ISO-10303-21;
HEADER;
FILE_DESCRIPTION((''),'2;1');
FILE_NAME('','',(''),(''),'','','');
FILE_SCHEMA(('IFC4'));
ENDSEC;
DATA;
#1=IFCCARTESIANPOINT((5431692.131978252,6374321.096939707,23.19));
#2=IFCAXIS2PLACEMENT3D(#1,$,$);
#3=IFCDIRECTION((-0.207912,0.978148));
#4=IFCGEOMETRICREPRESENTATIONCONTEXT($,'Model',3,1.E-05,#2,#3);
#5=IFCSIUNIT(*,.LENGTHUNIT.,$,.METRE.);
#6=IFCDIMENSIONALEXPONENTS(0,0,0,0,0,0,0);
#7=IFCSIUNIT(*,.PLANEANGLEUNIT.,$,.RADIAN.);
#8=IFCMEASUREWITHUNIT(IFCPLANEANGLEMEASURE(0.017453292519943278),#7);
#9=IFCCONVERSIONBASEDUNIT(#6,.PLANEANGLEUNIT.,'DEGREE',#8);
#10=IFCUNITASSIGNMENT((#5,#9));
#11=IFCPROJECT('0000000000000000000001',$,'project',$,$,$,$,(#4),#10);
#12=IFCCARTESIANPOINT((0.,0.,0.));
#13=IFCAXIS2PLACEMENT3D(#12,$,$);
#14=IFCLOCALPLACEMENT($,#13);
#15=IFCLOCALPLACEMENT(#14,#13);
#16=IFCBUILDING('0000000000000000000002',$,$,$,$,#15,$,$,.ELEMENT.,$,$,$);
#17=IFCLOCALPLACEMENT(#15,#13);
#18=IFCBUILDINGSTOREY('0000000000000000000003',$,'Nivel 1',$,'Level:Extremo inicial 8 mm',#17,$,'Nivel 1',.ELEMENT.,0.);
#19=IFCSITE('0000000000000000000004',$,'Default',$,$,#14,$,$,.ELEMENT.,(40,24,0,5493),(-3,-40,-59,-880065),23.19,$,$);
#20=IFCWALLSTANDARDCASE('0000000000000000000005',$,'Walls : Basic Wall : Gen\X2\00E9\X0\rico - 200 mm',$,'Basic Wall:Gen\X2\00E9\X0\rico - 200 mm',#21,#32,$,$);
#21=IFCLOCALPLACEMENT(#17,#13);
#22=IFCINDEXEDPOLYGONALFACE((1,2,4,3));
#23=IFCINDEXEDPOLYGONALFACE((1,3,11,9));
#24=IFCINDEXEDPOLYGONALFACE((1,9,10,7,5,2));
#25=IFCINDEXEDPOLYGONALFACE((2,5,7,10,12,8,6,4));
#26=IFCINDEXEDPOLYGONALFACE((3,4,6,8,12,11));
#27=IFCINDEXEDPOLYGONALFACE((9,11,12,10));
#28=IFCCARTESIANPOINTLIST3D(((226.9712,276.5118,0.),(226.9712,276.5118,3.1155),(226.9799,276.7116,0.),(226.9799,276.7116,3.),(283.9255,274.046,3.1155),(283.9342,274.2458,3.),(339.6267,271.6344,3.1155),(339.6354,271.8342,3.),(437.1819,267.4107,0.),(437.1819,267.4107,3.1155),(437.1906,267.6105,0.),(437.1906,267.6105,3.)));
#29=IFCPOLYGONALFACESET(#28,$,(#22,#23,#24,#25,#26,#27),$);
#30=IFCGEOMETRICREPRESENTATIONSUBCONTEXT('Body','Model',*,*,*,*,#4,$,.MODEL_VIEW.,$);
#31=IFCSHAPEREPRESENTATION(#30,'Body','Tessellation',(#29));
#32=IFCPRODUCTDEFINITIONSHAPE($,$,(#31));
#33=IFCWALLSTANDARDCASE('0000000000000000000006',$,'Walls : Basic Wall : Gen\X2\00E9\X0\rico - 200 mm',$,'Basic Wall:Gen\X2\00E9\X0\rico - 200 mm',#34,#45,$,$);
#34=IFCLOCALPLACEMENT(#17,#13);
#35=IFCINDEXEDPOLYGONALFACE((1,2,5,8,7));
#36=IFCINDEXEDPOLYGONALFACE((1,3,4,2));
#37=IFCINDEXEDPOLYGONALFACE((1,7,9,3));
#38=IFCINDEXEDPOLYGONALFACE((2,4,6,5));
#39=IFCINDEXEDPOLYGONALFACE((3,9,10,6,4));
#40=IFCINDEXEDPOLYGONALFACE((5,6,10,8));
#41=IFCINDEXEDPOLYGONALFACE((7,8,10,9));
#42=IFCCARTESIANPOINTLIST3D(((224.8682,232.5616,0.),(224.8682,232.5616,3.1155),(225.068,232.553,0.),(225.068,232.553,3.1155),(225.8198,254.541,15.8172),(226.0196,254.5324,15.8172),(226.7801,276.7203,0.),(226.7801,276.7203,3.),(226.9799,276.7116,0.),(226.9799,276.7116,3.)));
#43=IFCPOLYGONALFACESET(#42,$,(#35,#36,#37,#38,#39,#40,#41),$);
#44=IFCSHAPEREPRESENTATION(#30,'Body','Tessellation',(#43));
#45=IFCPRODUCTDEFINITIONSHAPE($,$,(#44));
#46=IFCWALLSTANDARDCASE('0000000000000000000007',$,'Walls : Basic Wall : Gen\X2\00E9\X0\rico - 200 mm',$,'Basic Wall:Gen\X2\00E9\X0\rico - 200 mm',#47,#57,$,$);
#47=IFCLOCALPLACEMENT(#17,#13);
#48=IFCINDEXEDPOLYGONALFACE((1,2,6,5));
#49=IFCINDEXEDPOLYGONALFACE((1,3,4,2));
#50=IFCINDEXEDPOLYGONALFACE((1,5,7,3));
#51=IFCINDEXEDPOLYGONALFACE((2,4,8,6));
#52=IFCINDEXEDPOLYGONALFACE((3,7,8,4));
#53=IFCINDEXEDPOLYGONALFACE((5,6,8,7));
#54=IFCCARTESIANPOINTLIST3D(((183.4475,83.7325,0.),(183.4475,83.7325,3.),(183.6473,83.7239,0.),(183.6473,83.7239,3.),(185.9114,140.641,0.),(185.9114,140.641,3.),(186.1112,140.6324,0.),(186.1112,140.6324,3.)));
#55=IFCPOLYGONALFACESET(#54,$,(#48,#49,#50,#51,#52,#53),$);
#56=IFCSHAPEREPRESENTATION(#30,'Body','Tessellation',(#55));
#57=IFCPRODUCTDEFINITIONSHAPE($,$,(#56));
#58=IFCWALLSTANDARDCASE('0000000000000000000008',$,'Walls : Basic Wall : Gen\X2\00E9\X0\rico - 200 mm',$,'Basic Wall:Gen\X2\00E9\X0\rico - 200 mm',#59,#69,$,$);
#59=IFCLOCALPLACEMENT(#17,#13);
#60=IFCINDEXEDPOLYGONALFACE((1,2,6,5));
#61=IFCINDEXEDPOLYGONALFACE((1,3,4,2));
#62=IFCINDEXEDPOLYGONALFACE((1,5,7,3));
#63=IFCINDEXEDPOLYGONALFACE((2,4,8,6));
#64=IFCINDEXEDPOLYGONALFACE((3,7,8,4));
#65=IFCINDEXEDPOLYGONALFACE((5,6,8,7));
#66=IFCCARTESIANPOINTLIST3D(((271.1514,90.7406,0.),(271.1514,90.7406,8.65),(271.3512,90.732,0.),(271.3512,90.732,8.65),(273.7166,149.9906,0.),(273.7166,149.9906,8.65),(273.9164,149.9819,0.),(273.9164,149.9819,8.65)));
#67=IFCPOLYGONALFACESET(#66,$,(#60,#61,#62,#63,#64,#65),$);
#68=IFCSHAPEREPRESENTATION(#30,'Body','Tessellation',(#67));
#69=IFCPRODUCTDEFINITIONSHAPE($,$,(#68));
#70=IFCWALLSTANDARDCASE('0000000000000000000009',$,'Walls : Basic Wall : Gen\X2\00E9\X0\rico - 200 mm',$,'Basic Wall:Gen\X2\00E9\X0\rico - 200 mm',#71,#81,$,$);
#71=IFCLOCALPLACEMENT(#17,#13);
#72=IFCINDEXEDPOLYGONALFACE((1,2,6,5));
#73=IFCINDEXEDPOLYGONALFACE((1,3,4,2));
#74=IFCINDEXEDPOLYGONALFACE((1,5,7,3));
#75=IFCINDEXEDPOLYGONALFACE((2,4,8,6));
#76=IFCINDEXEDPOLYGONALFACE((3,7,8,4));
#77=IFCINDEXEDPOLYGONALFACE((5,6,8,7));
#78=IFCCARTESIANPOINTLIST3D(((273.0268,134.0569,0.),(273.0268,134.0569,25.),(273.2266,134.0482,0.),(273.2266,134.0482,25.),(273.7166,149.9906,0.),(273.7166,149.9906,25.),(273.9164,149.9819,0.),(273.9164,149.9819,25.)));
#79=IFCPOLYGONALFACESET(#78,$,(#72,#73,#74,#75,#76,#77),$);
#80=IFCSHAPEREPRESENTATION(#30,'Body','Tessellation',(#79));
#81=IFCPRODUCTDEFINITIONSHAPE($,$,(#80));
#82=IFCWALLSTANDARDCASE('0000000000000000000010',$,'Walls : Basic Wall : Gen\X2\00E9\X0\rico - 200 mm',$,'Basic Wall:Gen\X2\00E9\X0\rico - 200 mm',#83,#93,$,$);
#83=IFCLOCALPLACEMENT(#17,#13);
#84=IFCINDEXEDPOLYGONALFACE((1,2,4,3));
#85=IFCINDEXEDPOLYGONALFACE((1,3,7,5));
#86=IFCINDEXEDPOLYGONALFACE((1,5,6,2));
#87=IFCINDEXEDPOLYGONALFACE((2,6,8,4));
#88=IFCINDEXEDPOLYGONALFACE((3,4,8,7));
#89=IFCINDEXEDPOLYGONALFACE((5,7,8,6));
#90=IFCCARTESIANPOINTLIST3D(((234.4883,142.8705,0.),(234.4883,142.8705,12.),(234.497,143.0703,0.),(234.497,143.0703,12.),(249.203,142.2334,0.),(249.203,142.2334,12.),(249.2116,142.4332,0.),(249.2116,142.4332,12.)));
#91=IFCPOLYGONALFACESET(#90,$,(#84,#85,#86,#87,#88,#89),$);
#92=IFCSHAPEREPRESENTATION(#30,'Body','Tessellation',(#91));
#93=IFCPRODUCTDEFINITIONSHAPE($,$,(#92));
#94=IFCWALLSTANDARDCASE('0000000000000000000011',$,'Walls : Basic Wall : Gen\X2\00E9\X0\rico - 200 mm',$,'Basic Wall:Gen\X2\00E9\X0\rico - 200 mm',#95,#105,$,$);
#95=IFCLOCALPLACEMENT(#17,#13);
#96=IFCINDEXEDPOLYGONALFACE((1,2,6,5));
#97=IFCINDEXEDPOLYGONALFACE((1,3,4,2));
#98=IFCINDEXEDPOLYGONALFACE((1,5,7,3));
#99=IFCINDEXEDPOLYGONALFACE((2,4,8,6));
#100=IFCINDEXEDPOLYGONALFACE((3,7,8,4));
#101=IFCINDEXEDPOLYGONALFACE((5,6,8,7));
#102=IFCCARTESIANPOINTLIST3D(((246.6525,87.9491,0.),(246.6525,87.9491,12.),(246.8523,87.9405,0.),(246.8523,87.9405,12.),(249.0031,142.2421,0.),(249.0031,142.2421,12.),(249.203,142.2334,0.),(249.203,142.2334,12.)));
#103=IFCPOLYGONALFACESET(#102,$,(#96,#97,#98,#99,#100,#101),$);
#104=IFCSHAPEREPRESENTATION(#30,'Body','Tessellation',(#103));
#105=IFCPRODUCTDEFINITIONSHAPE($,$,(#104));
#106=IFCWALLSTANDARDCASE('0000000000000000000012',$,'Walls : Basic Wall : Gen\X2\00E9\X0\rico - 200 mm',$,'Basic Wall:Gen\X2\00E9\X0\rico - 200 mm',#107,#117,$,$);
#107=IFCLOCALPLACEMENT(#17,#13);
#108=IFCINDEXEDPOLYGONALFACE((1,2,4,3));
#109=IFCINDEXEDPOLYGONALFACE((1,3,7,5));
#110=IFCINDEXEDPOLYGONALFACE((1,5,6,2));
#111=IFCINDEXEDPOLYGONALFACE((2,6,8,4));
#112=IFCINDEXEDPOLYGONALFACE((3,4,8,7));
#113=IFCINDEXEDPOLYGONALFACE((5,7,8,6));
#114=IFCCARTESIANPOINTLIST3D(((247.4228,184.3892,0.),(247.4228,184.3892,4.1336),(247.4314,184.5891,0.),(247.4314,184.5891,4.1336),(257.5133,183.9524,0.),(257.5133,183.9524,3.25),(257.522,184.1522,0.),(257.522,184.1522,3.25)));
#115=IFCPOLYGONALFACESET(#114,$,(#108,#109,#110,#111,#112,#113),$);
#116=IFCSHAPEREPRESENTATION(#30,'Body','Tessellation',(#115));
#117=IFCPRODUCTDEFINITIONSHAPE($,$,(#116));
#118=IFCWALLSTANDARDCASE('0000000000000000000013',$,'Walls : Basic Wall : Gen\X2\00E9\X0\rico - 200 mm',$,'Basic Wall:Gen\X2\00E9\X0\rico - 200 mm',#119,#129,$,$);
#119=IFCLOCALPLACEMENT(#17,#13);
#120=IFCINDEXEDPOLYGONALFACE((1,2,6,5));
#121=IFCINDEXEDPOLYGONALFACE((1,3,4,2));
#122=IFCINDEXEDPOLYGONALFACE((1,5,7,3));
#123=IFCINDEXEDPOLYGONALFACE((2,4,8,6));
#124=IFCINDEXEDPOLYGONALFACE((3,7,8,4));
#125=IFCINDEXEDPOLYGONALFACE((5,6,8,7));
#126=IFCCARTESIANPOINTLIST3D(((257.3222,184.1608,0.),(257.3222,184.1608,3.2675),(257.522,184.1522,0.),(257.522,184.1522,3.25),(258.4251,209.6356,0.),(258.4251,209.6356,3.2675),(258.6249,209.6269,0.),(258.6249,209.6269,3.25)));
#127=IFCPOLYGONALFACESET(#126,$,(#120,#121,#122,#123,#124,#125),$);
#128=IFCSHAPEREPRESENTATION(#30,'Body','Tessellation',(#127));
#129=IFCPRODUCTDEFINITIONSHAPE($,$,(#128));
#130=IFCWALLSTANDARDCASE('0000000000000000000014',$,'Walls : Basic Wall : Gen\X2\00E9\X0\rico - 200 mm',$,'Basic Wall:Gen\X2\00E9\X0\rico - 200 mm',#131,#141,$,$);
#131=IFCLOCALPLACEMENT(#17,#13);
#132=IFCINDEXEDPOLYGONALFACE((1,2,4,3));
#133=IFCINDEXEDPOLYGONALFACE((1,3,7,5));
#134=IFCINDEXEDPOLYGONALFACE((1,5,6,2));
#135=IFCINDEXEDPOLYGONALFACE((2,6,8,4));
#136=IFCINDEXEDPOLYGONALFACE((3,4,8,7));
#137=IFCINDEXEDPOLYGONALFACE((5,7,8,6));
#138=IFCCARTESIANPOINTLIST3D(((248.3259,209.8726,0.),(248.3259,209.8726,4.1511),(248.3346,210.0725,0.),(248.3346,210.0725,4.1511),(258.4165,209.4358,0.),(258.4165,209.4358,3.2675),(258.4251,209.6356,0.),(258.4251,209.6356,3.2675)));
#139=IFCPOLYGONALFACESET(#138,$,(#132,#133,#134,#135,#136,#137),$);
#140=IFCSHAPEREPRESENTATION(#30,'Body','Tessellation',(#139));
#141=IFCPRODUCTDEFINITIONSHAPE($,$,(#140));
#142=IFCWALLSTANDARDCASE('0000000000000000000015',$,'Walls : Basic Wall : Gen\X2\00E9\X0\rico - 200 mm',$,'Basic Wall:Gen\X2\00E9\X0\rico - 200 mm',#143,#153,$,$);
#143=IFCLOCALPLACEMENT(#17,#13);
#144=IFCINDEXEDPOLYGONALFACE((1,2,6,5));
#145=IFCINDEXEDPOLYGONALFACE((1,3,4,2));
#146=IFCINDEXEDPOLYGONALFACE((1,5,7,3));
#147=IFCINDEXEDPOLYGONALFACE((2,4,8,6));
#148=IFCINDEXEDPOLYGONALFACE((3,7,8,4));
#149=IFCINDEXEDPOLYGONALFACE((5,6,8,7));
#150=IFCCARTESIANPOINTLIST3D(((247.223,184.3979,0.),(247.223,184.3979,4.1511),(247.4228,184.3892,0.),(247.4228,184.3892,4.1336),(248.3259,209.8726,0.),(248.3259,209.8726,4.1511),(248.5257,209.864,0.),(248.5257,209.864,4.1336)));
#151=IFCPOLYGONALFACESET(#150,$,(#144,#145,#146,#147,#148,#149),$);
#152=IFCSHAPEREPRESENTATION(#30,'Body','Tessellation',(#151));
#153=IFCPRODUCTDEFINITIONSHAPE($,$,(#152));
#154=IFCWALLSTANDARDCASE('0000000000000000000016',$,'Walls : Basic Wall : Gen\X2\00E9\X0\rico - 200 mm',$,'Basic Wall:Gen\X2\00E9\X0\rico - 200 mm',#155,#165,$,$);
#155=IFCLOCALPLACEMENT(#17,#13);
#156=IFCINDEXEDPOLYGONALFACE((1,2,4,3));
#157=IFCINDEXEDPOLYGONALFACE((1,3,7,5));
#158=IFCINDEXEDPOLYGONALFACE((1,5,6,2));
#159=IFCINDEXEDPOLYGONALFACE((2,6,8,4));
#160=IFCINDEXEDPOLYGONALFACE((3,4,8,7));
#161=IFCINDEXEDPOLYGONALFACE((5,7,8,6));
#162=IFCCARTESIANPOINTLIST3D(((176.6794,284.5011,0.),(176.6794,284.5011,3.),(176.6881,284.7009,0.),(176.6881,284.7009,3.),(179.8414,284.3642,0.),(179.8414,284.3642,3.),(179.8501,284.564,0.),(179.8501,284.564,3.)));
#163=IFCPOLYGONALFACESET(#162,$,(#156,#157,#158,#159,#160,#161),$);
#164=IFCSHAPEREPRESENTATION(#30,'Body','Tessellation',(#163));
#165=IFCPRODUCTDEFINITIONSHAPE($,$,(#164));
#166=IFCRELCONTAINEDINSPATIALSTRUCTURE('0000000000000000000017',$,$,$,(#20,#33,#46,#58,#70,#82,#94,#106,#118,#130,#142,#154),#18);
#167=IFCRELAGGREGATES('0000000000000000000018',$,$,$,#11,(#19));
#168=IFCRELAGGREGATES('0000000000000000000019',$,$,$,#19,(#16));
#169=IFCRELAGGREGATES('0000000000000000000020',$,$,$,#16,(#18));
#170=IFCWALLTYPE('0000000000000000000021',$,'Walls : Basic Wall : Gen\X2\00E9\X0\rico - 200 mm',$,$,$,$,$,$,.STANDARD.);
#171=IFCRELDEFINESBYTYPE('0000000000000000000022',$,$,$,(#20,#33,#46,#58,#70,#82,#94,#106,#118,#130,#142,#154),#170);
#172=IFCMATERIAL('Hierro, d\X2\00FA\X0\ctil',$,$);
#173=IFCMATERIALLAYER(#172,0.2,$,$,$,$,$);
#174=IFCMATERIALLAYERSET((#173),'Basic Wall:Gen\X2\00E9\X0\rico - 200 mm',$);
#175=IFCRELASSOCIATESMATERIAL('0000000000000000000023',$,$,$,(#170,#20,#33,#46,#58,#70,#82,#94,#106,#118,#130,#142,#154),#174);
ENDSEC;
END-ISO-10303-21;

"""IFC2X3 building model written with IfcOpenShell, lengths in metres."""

from ifc_helpers import new_model, entity, si_unit, converted_unit, direction, frame, frame_2d, origin, place, context, subcontext, project, spatial, polyline, rectangle, extrude, clip, bounded_halfspace, material, layer, layer_set, layer_usage, type_object, element, save


model = new_model("IFC2X3")

# Units and contexts
model_context = context("Model", 3, precision=1e-05, world=frame((5431692.131978252, 6374321.096939707, 23.19)), true_north=direction((-0.207912, 0.978148)))
body_context = subcontext(model_context, "Body", "Model", "MODEL_VIEW")
ifc_project = project(units=[si_unit("LENGTHUNIT", "METRE"), converted_unit("PLANEANGLEUNIT", "DEGREE", entity("IfcPlaneAngleMeasure", 0.017453292519943278), si_unit("PLANEANGLEUNIT", "RADIAN"), dimensions=[0, 0, 0, 0, 0, 0, 0])], contexts=[model_context])

# Site, building, storey
site_placement = place(None, origin())
site = spatial("IfcSite", under=ifc_project, at=site_placement, Name="Default", CompositionType="ELEMENT", RefLatitude=(40, 24, 0, 5493), RefLongitude=(-3, -40, -59, -880065), RefElevation=23.19)
building_placement = place(site_placement, origin())
building = spatial("IfcBuilding", under=site, at=building_placement, CompositionType="ELEMENT")
storey_placement = place(building_placement, origin())
storey = spatial("IfcBuildingStorey", under=building, at=storey_placement, Name="Nivel 1", ObjectType="Level:Extremo inicial 8 mm", LongName="Nivel 1", CompositionType="ELEMENT", Elevation=0.0)

# Walls
ifc_material_1 = material(Name="Hierro, dúctil")
ifc_layer_1 = layer(ifc_material_1, 0.2)
ifc_layer_set_1 = layer_set([ifc_layer_1], Name="Basic Wall:Genérico - 200 mm")
ifc_layer_usage_1 = layer_usage(ifc_layer_set_1, "AXIS2", "NEGATIVE", 0.1)
wall_type = type_object("IfcWallType", Name="Walls : Basic Wall : Genérico - 200 mm", PredefinedType="STANDARD", material=ifc_layer_set_1)
wall_1_placement = place(storey_placement, frame((226.9756, 276.6117, 0.0), z_axis=(0.0, 0.0, 1.0), x_axis=(0.999064, -0.043255, 0.0)))
element("IfcWallStandardCase", 1, at=wall_1_placement, inside=storey, type_object=wall_type, material=ifc_layer_usage_1, Name="Walls : Basic Wall : Genérico - 200 mm", ObjectType="Basic Wall:Genérico - 200 mm", context=body_context, shape_type="Clipping", body=[
    clip(clip(clip(extrude(rectangle(XDim=210.4076, YDim=0.2, at=frame_2d((105.2038, 0.0), x_axis=(-1.0, 0.0))), origin(), (0.0, 0.0, 1.0), 3.1155), bounded_halfspace(frame((0.0, -0.1, 3.1155), z_axis=(0.0, 0.5, 0.866025), x_axis=(-1.0, 0.0, 0.0)), False, frame((0.0, -0.1, 3.1155)), polyline([(0.0, 0.0), (57.0076, 0.0), (57.0076, 0.2), (0.0, 0.2), (0.0, 0.0)]))), bounded_halfspace(frame((112.761, -0.1, 3.1155), z_axis=(0.0, 0.5, 0.866025), x_axis=(-1.0, 0.0, 0.0)), False, frame((112.761, -0.1, 3.1155)), polyline([(0.0, 0.0), (97.4466, 0.0), (97.6466, 0.0), (97.6466, 0.2), (0.0, 0.2), (0.0, 0.0)]))), bounded_halfspace(frame((112.761, -0.1, 3.1155), z_axis=(0.0, 0.5, 0.866025), x_axis=(-1.0, 0.0, 0.0)), False, frame((112.761, -0.1, 3.1155)), polyline([(0.0, 0.0), (0.0, 0.2), (-55.7534, 0.2), (-55.7534, 0.0), (0.0, 0.0)]))),
])
ifc_layer_usage_2 = layer_usage(ifc_layer_set_1, "AXIS2", "NEGATIVE", 0.1)
wall_2_placement = place(storey_placement, frame((224.9681, 232.5573, 0.0), z_axis=(0.0, 0.0, 1.0), x_axis=(0.043255, 0.999064, 0.0)))
element("IfcWallStandardCase", 2, at=wall_2_placement, inside=storey, type_object=wall_type, material=ifc_layer_usage_2, Name="Walls : Basic Wall : Genérico - 200 mm", ObjectType="Basic Wall:Genérico - 200 mm", context=body_context, shape_type="Clipping", body=[
    clip(clip(extrude(rectangle(XDim=44.2, YDim=0.2, at=frame_2d((22.1, 0.0), x_axis=(-1.0, 0.0))), origin(), (0.0, 0.0, 1.0), 15.8172), bounded_halfspace(frame((22.0, -0.1, 15.8172), z_axis=(0.5, 0.0, 0.866025), x_axis=(0.0, 1.0, 0.0)), False, frame((22.0, -0.1, 15.8172)), polyline([(0.0, 0.0), (22.0, 0.0), (22.2, 0.0), (22.2, 0.2), (0.0, 0.2), (0.0, 0.0)]))), bounded_halfspace(frame((0.0, -0.1, 3.1155), z_axis=(-0.5, 0.0, 0.866025), x_axis=(0.0, -1.0, 0.0)), False, frame((0.0, -0.1, 3.1155)), polyline([(0.0, 0.0), (22.0, 0.0), (22.0, 0.2), (0.0, 0.2), (0.0, 0.0)]))),
])
ifc_layer_usage_3 = layer_usage(ifc_layer_set_1, "AXIS2", "NEGATIVE", 0.1)
wall_3_placement = place(storey_placement, frame((186.0113, 140.6367, 0.0), z_axis=(0.0, 0.0, 1.0), x_axis=(-0.043255, -0.999064, 0.0)))
element("IfcWallStandardCase", 3, at=wall_3_placement, inside=storey, type_object=wall_type, material=ifc_layer_usage_3, Name="Walls : Basic Wall : Genérico - 200 mm", ObjectType="Basic Wall:Genérico - 200 mm", context=body_context, shape_type="SweptSolid", body=[
    extrude(rectangle(XDim=56.9618, YDim=0.2, at=frame_2d((28.4809, 0.0), x_axis=(-1.0, 0.0))), origin(), (0.0, 0.0, 1.0), 3.0),
])
ifc_layer_usage_4 = layer_usage(ifc_layer_set_1, "AXIS2", "NEGATIVE", 0.1)
wall_4_placement = place(storey_placement, frame((273.8165, 149.9863, 0.0), z_axis=(0.0, 0.0, 1.0), x_axis=(-0.043255, -0.999064, 0.0)))
element("IfcWallStandardCase", 4, at=wall_4_placement, inside=storey, type_object=wall_type, material=ifc_layer_usage_4, Name="Walls : Basic Wall : Genérico - 200 mm", ObjectType="Basic Wall:Genérico - 200 mm", context=body_context, shape_type="SweptSolid", body=[
    extrude(rectangle(XDim=59.3055, YDim=0.2, at=frame_2d((29.6527, 0.0), x_axis=(-1.0, 0.0))), origin(), (0.0, 0.0, 1.0), 8.65),
])
ifc_layer_usage_5 = layer_usage(ifc_layer_set_1, "AXIS2", "NEGATIVE", 0.1)
wall_5_placement = place(storey_placement, frame((273.8165, 149.9863, 0.0), z_axis=(0.0, 0.0, 1.0), x_axis=(-0.043255, -0.999064, 0.0)))
element("IfcWallStandardCase", 5, at=wall_5_placement, inside=storey, type_object=wall_type, material=ifc_layer_usage_5, Name="Walls : Basic Wall : Genérico - 200 mm", ObjectType="Basic Wall:Genérico - 200 mm", context=body_context, shape_type="SweptSolid", body=[
    extrude(rectangle(XDim=15.9486, YDim=0.2, at=frame_2d((7.9743, 0.0), x_axis=(-1.0, 0.0))), origin(), (0.0, 0.0, 1.0), 25.0),
])
ifc_layer_usage_6 = layer_usage(ifc_layer_set_1, "AXIS2", "NEGATIVE", 0.1)
wall_6_placement = place(storey_placement, frame((234.4927, 142.9704, 0.0), z_axis=(0.0, 0.0, 1.0), x_axis=(0.999064, -0.043255, 0.0)))
element("IfcWallStandardCase", 6, at=wall_6_placement, inside=storey, type_object=wall_type, material=ifc_layer_usage_6, Name="Walls : Basic Wall : Genérico - 200 mm", ObjectType="Basic Wall:Genérico - 200 mm", context=body_context, shape_type="Clipping", body=[
    clip(extrude(rectangle(XDim=14.7284, YDim=0.2, at=frame_2d((7.3642, 0.0), x_axis=(-1.0, 0.0))), origin(), (0.0, 0.0, 1.0), 12.0), bounded_halfspace(frame((0.0, -0.1, 12.0), z_axis=(0.0, 0.0, 1.0), x_axis=(0.999064, 0.043255, 0.0)), False, frame((0.0, -0.1, 12.0)), polyline([(0.0, 0.0), (0.2, 0.0), (14.5284, 0.0), (14.7284, 0.0), (14.7284, 0.2), (0.0, 0.2), (0.0, 0.0)]))),
])
ifc_layer_usage_7 = layer_usage(ifc_layer_set_1, "AXIS2", "NEGATIVE", 0.1)
wall_7_placement = place(storey_placement, frame((249.103, 142.2377, 0.0), z_axis=(0.0, 0.0, 1.0), x_axis=(-0.043255, -0.999064, 0.0)))
element("IfcWallStandardCase", 7, at=wall_7_placement, inside=storey, type_object=wall_type, material=ifc_layer_usage_7, Name="Walls : Basic Wall : Genérico - 200 mm", ObjectType="Basic Wall:Genérico - 200 mm", context=body_context, shape_type="SweptSolid", body=[
    extrude(rectangle(XDim=54.3438, YDim=0.2, at=frame_2d((27.1719, 0.0), x_axis=(-1.0, 0.0))), origin(), (0.0, 0.0, 1.0), 12.0),
])
ifc_layer_usage_8 = layer_usage(ifc_layer_set_1, "AXIS2", "NEGATIVE", 0.1)
wall_8_placement = place(storey_placement, frame((247.4271, 184.4892, 0.0), z_axis=(0.0, 0.0, 1.0), x_axis=(0.999064, -0.043255, 0.0)))
element("IfcWallStandardCase", 8, at=wall_8_placement, inside=storey, type_object=wall_type, material=ifc_layer_usage_8, Name="Walls : Basic Wall : Genérico - 200 mm", ObjectType="Basic Wall:Genérico - 200 mm", context=body_context, shape_type="Clipping", body=[
    clip(extrude(rectangle(XDim=10.1, YDim=0.2, at=frame_2d((5.05, 0.0), x_axis=(-1.0, 0.0))), origin(), (0.0, 0.0, 1.0), 4.1336), bounded_halfspace(frame((0.0, -0.1, 4.1336), z_axis=(0.087156, 0.0, 0.996195), x_axis=(0.0, 1.0, 0.0)), False, frame((0.0, -0.1, 4.1336)), polyline([(0.0, 0.0), (10.1, 0.0), (10.1, 0.2), (9.9, 0.2), (0.0, 0.2), (0.0, 0.0)]))),
])
ifc_layer_usage_9 = layer_usage(ifc_layer_set_1, "AXIS2", "NEGATIVE", 0.1)
wall_9_placement = place(storey_placement, frame((257.4221, 184.1565, 0.0), z_axis=(0.0, 0.0, 1.0), x_axis=(0.043255, 0.999064, 0.0)))
element("IfcWallStandardCase", 9, at=wall_9_placement, inside=storey, type_object=wall_type, material=ifc_layer_usage_9, Name="Walls : Basic Wall : Genérico - 200 mm", ObjectType="Basic Wall:Genérico - 200 mm", context=body_context, shape_type="Clipping", body=[
    clip(extrude(rectangle(XDim=25.4986, YDim=0.2, at=frame_2d((12.7493, 0.0), x_axis=(-1.0, 0.0))), origin(), (0.0, 0.0, 1.0), 3.2675), bounded_halfspace(frame((0.0, -0.1, 3.25), z_axis=(0.0, -0.087156, 0.996195), x_axis=(1.0, 0.0, 0.0)), False, frame((0.0, -0.1, 3.25)), polyline([(0.0, 0.0), (25.4986, 0.0), (25.4986, 0.2), (25.2986, 0.2), (0.0, 0.2), (0.0, 0.0)]))),
])
ifc_layer_usage_10 = layer_usage(ifc_layer_set_1, "AXIS2", "NEGATIVE", 0.1)
wall_10_placement = place(storey_placement, frame((258.4208, 209.5357, 0.0), z_axis=(0.0, 0.0, 1.0), x_axis=(-0.999064, 0.043255, 0.0)))
element("IfcWallStandardCase", 10, at=wall_10_placement, inside=storey, type_object=wall_type, material=ifc_layer_usage_10, Name="Walls : Basic Wall : Genérico - 200 mm", ObjectType="Basic Wall:Genérico - 200 mm", context=body_context, shape_type="Clipping", body=[
    clip(extrude(rectangle(XDim=10.1, YDim=0.2, at=frame_2d((5.05, 0.0), x_axis=(-1.0, 0.0))), origin(), (0.0, 0.0, 1.0), 4.1511), bounded_halfspace(frame((0.0, -0.1, 3.2675), z_axis=(-0.087156, 0.0, 0.996195), x_axis=(0.0, -1.0, 0.0)), False, frame((0.0, -0.1, 3.2675)), polyline([(0.0, 0.0), (10.1, 0.0), (10.1, 0.2), (9.9, 0.2), (0.0, 0.2), (0.0, 0.0)]))),
])
ifc_layer_usage_11 = layer_usage(ifc_layer_set_1, "AXIS2", "NEGATIVE", 0.1)
wall_11_placement = place(storey_placement, frame((248.4258, 209.8683, 0.0), z_axis=(0.0, 0.0, 1.0), x_axis=(-0.043255, -0.999064, 0.0)))
element("IfcWallStandardCase", 11, at=wall_11_placement, inside=storey, type_object=wall_type, material=ifc_layer_usage_11, Name="Walls : Basic Wall : Genérico - 200 mm", ObjectType="Basic Wall:Genérico - 200 mm", context=body_context, shape_type="Clipping", body=[
    clip(extrude(rectangle(XDim=25.4986, YDim=0.2, at=frame_2d((12.7493, 0.0), x_axis=(-1.0, 0.0))), origin(), (0.0, 0.0, 1.0), 4.1511), bounded_halfspace(frame((0.0, -0.1, 4.1511), z_axis=(0.0, 0.087156, 0.996195), x_axis=(-1.0, 0.0, 0.0)), False, frame((0.0, -0.1, 4.1511)), polyline([(0.0, 0.0), (25.4986, 0.0), (25.4986, 0.2), (25.2986, 0.2), (0.0, 0.2), (0.0, 0.0)]))),
])
ifc_layer_usage_12 = layer_usage(ifc_layer_set_1, "AXIS2", "NEGATIVE", 0.1)
wall_12_placement = place(storey_placement, frame((176.6838, 284.601, 0.0), z_axis=(0.0, 0.0, 1.0), x_axis=(0.999064, -0.043255, 0.0)))
element("IfcWallStandardCase", 12, at=wall_12_placement, inside=storey, type_object=wall_type, material=ifc_layer_usage_12, Name="Walls : Basic Wall : Genérico - 200 mm", ObjectType="Basic Wall:Genérico - 200 mm", context=body_context, shape_type="SweptSolid", body=[
    extrude(rectangle(XDim=3.165, YDim=0.2, at=frame_2d((1.5825, 0.0), x_axis=(-1.0, 0.0))), origin(), (0.0, 0.0, 1.0), 3.0),
])

save(model, "model.ifc")
